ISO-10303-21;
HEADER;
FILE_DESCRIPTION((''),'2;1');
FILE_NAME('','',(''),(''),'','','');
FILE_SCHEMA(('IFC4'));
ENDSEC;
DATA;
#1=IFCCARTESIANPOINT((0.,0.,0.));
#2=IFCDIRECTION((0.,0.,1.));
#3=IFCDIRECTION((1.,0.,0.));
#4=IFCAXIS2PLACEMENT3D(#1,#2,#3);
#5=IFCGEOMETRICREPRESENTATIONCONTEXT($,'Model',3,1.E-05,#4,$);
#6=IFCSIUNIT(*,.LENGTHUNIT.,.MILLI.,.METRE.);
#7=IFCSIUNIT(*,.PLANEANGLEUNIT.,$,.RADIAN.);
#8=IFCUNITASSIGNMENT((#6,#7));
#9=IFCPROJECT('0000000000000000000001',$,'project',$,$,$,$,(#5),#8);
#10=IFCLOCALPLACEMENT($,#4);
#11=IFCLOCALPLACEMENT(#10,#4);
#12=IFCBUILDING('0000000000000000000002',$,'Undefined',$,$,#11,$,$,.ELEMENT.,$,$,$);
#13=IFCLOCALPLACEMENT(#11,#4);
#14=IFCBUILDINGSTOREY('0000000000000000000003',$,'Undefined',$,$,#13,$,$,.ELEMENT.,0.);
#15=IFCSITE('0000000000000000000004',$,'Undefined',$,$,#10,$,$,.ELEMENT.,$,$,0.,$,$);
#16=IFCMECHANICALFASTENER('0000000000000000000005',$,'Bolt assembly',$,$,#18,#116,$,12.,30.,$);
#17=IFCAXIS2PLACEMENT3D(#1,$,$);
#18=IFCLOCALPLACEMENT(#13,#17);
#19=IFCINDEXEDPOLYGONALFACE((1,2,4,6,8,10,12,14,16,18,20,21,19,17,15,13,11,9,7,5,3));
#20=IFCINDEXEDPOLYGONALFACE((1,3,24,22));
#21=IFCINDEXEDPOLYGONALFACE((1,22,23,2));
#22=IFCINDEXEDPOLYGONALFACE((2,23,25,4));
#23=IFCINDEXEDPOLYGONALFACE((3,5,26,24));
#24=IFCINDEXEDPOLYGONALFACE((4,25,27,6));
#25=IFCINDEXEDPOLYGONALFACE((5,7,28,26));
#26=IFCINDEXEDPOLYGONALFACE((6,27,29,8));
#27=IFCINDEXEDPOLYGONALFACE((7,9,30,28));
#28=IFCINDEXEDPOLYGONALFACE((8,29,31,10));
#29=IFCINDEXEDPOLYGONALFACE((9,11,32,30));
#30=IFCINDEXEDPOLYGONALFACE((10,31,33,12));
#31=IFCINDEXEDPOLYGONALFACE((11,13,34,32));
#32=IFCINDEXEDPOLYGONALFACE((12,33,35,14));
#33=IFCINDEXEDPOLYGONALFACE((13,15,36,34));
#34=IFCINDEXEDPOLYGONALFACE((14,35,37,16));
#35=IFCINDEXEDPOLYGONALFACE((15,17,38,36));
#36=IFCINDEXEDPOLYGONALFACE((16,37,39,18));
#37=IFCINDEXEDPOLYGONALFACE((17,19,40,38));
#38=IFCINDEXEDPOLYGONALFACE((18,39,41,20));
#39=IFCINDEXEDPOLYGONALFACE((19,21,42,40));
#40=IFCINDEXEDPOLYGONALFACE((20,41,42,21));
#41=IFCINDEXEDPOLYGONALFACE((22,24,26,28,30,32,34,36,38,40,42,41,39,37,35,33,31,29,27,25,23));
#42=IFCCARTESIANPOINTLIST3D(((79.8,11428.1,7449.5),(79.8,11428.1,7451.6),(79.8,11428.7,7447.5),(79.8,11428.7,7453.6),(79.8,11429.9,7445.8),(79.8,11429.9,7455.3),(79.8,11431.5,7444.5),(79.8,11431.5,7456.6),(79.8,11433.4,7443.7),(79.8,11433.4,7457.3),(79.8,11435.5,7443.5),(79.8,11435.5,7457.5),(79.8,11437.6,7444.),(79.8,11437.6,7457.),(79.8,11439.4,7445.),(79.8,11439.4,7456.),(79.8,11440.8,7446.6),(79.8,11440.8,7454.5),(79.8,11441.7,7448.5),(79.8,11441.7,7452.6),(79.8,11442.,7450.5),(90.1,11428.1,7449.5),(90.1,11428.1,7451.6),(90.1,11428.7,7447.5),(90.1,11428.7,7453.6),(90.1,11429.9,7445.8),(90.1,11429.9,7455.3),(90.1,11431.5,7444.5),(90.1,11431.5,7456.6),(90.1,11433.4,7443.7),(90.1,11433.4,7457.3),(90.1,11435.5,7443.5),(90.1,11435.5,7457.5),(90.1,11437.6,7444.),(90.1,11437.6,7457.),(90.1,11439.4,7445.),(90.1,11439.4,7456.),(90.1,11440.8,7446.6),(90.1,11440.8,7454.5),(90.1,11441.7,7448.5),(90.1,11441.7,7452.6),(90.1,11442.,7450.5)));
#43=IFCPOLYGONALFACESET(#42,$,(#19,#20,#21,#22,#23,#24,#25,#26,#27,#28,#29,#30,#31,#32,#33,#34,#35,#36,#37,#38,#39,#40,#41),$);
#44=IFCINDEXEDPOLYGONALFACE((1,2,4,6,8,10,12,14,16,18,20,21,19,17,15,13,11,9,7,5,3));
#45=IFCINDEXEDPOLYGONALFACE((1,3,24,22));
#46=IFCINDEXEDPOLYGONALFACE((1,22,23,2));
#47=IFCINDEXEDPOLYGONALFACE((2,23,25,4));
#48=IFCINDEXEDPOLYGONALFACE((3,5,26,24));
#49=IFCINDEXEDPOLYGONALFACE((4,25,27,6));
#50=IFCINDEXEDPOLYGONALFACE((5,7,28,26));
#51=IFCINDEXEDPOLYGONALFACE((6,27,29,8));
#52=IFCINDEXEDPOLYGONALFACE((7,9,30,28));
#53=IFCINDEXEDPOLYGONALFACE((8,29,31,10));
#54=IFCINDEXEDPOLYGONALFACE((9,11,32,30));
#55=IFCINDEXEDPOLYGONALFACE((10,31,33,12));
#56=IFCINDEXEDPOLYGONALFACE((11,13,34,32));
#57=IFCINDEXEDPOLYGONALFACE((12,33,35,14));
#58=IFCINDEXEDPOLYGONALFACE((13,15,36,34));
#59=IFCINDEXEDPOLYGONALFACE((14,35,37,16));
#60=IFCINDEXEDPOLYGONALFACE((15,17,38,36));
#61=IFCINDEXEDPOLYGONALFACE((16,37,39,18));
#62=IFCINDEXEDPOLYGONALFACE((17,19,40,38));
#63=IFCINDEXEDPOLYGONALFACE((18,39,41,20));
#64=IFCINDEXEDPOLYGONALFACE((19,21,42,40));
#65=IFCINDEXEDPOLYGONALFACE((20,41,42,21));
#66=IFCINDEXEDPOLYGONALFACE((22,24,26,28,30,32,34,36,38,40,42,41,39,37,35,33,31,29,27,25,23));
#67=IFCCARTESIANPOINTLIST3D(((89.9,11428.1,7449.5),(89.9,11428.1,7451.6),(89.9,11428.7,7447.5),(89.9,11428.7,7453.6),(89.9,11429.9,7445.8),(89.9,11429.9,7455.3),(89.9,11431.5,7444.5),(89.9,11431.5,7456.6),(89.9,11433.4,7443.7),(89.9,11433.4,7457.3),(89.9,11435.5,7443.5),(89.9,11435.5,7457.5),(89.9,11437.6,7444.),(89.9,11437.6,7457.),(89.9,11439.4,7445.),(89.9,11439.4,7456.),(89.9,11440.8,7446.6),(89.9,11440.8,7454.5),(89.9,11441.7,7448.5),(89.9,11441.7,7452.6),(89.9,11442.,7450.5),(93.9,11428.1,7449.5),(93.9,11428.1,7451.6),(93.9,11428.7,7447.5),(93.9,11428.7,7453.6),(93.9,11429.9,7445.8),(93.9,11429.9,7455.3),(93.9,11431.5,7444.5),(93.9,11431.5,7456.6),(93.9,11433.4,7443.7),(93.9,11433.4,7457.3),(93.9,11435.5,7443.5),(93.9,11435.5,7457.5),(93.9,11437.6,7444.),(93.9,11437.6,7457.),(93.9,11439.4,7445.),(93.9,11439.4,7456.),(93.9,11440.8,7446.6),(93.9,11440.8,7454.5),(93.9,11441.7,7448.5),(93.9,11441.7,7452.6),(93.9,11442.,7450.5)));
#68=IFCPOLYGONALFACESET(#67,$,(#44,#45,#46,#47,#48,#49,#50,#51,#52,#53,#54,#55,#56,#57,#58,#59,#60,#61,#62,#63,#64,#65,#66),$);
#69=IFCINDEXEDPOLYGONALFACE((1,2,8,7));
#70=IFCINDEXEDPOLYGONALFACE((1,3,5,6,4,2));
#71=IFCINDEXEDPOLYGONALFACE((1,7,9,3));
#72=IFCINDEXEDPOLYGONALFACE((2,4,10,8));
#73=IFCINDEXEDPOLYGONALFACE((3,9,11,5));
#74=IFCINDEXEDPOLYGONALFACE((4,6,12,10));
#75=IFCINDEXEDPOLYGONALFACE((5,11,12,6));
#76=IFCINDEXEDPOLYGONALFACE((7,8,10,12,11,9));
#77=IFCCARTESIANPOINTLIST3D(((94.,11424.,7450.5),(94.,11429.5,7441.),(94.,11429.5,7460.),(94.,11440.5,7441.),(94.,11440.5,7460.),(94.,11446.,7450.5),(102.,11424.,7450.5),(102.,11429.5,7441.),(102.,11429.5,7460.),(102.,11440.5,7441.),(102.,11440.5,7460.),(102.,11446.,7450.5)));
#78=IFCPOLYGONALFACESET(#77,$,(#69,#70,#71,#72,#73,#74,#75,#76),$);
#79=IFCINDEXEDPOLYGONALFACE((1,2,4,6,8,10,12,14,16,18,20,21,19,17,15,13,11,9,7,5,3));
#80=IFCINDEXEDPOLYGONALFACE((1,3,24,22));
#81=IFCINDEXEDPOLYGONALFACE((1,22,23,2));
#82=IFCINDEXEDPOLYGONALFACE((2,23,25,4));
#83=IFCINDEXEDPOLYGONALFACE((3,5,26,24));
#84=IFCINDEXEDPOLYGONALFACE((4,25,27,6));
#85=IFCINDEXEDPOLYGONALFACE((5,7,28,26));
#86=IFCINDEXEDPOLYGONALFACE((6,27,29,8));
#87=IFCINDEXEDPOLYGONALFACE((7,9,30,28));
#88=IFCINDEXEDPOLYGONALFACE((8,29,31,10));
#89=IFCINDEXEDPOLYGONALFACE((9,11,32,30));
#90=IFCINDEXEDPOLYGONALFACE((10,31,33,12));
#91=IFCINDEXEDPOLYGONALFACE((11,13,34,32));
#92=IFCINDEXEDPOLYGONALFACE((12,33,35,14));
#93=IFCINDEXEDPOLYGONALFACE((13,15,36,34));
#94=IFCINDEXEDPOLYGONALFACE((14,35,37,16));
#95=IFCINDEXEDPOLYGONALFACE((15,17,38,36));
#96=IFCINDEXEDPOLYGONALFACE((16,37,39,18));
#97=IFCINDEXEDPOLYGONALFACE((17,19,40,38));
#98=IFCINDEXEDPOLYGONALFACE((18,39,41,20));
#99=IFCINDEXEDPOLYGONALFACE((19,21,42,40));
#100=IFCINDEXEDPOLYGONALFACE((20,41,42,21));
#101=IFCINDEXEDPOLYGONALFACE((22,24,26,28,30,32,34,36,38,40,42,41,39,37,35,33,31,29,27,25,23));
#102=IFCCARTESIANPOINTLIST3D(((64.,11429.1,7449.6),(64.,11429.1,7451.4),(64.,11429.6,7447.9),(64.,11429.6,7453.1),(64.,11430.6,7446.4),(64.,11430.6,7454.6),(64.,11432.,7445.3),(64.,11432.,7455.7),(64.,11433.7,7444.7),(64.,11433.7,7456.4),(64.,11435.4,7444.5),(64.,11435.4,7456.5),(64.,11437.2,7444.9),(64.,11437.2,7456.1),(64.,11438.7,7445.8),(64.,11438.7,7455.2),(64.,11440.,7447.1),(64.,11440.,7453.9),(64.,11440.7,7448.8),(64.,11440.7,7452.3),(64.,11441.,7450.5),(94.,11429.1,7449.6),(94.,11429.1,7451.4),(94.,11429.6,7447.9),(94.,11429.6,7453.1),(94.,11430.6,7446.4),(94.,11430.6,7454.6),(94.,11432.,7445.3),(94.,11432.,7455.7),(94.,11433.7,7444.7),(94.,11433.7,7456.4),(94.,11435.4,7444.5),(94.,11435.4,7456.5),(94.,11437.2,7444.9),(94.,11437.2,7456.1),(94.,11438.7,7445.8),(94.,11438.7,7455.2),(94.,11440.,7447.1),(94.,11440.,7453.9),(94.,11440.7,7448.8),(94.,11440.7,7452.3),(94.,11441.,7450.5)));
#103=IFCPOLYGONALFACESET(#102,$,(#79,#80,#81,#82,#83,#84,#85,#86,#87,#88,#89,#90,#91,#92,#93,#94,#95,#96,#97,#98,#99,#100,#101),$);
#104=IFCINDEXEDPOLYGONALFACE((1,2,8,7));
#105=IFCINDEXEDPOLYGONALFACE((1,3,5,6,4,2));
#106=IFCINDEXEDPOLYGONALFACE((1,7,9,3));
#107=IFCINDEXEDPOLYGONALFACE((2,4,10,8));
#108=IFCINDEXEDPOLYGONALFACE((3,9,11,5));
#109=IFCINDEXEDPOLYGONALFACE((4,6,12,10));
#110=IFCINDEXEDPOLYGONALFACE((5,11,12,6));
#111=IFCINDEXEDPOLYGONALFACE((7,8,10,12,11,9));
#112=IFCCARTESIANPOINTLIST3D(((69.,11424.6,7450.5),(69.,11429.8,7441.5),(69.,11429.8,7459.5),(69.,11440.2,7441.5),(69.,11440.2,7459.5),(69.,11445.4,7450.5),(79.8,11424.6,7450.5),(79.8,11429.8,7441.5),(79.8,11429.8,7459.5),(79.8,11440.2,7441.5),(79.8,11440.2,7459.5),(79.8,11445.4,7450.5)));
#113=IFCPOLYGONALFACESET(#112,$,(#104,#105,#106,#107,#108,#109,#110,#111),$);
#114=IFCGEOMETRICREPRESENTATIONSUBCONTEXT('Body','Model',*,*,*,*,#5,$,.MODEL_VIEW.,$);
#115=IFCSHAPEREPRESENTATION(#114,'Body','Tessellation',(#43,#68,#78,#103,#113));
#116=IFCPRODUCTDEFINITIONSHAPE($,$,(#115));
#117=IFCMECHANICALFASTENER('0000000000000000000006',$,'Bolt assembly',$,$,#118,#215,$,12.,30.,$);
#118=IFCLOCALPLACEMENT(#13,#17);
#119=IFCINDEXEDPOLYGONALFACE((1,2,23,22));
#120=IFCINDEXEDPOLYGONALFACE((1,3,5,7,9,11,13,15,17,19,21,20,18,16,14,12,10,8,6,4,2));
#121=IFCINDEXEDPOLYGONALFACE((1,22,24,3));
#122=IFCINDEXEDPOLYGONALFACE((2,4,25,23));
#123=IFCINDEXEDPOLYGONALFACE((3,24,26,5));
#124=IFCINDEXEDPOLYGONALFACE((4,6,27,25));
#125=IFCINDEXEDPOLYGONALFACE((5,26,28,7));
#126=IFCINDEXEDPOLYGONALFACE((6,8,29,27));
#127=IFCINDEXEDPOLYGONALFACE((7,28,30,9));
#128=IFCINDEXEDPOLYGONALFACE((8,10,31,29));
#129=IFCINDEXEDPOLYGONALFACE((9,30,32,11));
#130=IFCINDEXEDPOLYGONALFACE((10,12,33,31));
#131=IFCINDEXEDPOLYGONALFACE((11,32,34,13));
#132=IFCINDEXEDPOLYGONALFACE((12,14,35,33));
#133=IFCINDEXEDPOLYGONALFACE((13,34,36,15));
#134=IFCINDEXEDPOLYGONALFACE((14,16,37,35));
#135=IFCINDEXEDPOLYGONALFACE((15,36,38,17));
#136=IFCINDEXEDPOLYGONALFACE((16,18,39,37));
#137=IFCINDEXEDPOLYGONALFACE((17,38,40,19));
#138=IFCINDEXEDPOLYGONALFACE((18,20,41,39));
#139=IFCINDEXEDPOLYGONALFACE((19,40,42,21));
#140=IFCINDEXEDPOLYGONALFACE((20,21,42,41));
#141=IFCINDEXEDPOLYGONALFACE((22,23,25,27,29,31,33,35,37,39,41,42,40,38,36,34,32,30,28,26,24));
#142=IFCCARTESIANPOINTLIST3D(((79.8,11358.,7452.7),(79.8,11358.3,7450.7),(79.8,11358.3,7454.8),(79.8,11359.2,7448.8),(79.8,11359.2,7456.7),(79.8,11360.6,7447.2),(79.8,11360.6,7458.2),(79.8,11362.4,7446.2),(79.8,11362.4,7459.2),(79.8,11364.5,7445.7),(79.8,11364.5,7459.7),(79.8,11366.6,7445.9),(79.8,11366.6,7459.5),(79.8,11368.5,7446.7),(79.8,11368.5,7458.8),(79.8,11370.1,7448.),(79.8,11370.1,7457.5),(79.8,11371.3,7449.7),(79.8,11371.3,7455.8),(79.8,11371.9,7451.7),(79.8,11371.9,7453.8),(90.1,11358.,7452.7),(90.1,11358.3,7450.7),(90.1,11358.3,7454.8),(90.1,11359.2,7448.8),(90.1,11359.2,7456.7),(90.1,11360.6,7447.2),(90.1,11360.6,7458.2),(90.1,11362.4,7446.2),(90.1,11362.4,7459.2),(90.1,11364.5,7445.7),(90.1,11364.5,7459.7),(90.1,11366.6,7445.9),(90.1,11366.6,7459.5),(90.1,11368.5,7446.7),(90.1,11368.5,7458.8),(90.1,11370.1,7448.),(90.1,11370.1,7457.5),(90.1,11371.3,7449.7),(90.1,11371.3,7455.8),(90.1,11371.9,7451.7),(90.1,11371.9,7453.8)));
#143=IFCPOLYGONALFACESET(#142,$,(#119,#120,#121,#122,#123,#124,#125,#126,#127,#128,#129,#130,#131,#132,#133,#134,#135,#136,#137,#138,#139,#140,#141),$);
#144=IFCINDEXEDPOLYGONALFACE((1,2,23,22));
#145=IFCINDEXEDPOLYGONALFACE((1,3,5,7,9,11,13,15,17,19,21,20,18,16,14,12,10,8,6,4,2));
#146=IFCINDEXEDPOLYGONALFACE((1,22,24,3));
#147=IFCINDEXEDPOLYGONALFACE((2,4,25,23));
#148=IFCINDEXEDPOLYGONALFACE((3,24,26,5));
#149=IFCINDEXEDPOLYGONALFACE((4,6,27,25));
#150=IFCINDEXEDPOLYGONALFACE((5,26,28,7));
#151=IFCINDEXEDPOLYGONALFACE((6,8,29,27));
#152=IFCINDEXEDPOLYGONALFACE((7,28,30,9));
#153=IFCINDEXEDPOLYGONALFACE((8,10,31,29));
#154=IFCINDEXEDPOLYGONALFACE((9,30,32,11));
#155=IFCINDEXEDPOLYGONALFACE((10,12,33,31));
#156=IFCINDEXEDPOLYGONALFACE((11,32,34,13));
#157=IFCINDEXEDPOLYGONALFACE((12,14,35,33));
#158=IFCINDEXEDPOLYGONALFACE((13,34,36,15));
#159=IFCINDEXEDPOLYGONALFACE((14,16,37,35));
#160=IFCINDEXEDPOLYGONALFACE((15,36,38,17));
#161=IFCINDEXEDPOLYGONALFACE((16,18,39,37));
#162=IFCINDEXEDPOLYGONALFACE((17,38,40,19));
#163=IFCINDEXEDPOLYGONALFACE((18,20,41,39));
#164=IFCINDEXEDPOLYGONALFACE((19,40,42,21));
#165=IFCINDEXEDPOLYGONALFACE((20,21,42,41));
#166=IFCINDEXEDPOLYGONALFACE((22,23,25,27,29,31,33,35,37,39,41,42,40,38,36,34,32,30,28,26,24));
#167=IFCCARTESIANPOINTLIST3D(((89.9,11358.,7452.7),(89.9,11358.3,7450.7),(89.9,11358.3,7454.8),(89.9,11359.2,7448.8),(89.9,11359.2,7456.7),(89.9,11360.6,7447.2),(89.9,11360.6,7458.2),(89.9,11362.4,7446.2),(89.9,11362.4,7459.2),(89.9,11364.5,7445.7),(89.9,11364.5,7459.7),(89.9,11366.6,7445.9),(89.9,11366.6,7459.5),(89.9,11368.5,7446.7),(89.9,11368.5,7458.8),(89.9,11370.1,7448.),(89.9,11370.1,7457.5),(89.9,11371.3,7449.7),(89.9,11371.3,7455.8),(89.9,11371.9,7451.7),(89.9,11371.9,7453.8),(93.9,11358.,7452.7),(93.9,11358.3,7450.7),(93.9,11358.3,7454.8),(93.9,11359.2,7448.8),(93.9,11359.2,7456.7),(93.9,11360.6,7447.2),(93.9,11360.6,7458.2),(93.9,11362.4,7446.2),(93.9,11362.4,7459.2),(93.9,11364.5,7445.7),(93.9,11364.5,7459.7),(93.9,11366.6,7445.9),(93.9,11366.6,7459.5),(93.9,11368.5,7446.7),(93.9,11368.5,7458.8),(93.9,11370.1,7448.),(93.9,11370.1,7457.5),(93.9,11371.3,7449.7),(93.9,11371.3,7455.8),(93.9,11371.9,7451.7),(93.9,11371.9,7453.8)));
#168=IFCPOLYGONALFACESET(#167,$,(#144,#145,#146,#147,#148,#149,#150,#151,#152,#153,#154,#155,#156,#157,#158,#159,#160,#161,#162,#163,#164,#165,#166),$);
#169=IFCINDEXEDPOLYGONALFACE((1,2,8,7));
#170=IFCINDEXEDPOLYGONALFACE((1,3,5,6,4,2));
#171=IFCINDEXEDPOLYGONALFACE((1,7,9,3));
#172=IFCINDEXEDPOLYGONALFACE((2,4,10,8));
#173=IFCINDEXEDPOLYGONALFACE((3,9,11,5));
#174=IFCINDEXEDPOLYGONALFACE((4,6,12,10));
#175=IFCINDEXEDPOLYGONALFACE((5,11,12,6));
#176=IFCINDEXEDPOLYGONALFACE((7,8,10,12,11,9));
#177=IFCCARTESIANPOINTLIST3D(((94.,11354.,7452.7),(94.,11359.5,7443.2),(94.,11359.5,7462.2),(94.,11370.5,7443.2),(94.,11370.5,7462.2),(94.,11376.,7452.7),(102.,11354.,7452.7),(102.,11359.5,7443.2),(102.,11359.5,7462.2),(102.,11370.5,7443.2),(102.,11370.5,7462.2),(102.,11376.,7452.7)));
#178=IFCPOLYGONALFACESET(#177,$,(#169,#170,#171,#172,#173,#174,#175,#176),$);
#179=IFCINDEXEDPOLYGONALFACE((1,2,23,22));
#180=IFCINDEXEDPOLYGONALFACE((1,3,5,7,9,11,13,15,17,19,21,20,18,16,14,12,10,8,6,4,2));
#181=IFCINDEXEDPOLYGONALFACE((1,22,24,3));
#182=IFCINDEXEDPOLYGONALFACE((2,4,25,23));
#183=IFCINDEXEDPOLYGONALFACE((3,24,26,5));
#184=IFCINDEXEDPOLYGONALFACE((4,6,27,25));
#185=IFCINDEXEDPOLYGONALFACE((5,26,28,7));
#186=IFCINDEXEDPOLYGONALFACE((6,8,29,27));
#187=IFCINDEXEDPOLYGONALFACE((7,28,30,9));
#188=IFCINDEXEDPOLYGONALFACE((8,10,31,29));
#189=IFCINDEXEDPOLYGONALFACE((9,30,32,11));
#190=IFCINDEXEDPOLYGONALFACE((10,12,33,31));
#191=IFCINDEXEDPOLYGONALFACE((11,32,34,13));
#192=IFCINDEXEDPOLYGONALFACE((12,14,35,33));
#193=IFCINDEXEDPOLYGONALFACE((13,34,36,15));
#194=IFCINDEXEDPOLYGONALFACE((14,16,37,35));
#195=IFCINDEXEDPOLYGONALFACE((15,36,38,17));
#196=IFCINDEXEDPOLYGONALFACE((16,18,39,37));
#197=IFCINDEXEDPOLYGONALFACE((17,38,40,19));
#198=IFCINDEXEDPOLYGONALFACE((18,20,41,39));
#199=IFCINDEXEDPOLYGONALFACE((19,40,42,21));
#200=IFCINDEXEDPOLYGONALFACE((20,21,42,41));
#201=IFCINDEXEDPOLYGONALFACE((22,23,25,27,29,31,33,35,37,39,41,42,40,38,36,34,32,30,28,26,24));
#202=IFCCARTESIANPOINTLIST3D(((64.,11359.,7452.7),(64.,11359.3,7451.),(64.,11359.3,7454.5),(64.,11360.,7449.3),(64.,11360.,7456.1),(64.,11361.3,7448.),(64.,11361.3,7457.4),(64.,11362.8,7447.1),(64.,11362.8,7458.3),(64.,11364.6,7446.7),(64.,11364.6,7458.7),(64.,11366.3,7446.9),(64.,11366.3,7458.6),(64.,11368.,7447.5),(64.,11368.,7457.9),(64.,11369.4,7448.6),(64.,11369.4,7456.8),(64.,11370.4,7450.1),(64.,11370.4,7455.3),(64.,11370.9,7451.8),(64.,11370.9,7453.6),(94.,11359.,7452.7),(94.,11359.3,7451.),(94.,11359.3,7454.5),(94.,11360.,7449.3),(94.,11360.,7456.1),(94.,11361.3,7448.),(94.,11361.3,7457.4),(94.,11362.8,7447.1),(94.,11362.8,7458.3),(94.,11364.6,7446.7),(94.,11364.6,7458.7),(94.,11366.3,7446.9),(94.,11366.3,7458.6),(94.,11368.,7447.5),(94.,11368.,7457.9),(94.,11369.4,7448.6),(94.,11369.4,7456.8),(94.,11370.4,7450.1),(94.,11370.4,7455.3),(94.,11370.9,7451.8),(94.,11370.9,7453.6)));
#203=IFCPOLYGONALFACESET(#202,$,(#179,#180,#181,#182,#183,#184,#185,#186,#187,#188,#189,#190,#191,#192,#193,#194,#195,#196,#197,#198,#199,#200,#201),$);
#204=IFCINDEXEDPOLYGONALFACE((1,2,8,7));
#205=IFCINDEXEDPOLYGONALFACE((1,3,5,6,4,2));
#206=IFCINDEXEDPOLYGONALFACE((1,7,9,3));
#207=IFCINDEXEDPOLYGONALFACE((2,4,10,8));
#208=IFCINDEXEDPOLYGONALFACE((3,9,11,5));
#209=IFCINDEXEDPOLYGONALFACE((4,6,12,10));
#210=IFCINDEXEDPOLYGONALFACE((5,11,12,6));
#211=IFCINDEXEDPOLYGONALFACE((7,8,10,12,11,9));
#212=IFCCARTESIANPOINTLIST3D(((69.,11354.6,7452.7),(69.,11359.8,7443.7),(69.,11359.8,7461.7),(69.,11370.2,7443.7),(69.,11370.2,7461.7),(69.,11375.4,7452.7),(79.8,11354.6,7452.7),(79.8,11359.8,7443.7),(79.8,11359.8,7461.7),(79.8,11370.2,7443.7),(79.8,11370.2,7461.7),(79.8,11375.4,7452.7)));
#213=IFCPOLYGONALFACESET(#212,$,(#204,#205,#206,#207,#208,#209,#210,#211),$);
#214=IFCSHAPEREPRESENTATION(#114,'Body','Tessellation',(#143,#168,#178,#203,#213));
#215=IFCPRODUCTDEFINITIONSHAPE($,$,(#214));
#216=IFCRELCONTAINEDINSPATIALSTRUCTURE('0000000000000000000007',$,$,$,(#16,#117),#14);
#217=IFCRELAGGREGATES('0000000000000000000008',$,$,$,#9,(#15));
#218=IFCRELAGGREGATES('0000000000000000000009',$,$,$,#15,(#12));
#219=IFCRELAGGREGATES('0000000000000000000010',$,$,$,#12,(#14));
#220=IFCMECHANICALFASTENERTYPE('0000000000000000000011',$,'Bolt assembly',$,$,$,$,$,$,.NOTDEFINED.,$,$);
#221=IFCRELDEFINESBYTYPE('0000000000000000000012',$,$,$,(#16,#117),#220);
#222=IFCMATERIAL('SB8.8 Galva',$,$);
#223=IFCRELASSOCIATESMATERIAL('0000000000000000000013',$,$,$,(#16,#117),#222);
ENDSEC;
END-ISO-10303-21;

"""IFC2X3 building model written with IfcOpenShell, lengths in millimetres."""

from ifc_helpers import new_model, si_unit, frame, origin_with_axes, origin_2d_with_axis, place, context, subcontext, project, spatial, polyline, circle, outline, extrude, source, transform, mapped, material, type_object, element, save


model = new_model("IFC2X3")

# Units and contexts
model_context = context("Model", 3, precision=1e-05, world=origin_with_axes())
body_context = subcontext(model_context, "Body", "Model", "MODEL_VIEW")
ifc_project = project(units=[si_unit("LENGTHUNIT", "METRE", prefix="MILLI"), si_unit("PLANEANGLEUNIT", "RADIAN")], contexts=[model_context])

# Site, building, storey
site_placement = place(None, origin_with_axes())
site = spatial("IfcSite", under=ifc_project, at=site_placement, Name="Undefined", CompositionType="ELEMENT", RefElevation=0.0)
building_placement = place(site_placement, origin_with_axes())
building = spatial("IfcBuilding", under=site, at=building_placement, Name="Undefined", CompositionType="ELEMENT")
storey_placement = place(building_placement, origin_with_axes())
storey = spatial("IfcBuildingStorey", under=building, at=storey_placement, Name="Undefined", CompositionType="ELEMENT", Elevation=0.0)

# Mechanical fasteners
mechanical_fastener_type = type_object("IfcMechanicalFastenerType", Name="Bolt assembly")
ifc_material_1 = material(Name="SB8.8 Galva")
shared_shape_1 = source(origin_with_axes(), body_context, "Body", "SweptSolid", [
    extrude(circle(Radius=7.0, at=origin_2d_with_axis()), frame((0.0, -0.1, 0.0), z_axis=(0.0, 1.0, 0.0), x_axis=(1.0, 0.0, 0.0)), (0.0, 0.0, 1.0), 10.3),
    extrude(circle(Radius=7.0, at=origin_2d_with_axis()), frame((0.0, -3.9, 0.0), z_axis=(0.0, 1.0, 0.0), x_axis=(1.0, 0.0, 0.0)), (0.0, 0.0, 1.0), 4.0),
    extrude(outline(polyline([(11.0, 0.0), (5.5, 9.5), (-5.5, 9.5), (-11.0, 0.0), (-5.5, -9.5), (5.5, -9.5), (11.0, 0.0)])), frame((0.0, -12.0, 0.0), z_axis=(0.0, 1.0, 0.0), x_axis=(1.0, 0.0, 0.0)), (0.0, 0.0, 1.0), 8.0),
    extrude(circle(Radius=6.0, at=origin_2d_with_axis()), frame((0.0, -4.0, 0.0), z_axis=(0.0, 1.0, 0.0), x_axis=(1.0, 0.0, 0.0)), (0.0, 0.0, 1.0), 30.0),
    extrude(outline(polyline([(10.4, 0.0), (5.2, 9.0), (-5.2, 9.0), (-10.4, 0.0), (-5.2, -9.0), (5.2, -9.0), (10.4, 0.0)])), frame((0.0, 10.2, 0.0), z_axis=(0.0, 1.0, 0.0), x_axis=(1.0, 0.0, 0.0)), (0.0, 0.0, 1.0), 10.8),
])
for number, where, z_axis, x_axis, name in (
    (1, (90.0, 11435.0, 7450.5), (0.0, 0.0, 1.0), (0.0, 1.0, 0.0), "Bolt assembly"),
    (2, (90.0, 11365.0, 7452.7), (0.0, 0.0, -1.0), (0.0, -1.0, 0.0), "Bolt assembly"),
):
    element("IfcMechanicalFastener", number, at=place(storey_placement, frame(where, z_axis=z_axis, x_axis=x_axis)), inside=storey, type_object=mechanical_fastener_type, material=ifc_material_1, Name=name, NominalDiameter=12.0, NominalLength=30.0, context=body_context, shape_type="MappedRepresentation", body=[
        mapped(shared_shape_1, transform((0.0, 0.0, 0.0))),
    ])

save(model, "model.ifc")
